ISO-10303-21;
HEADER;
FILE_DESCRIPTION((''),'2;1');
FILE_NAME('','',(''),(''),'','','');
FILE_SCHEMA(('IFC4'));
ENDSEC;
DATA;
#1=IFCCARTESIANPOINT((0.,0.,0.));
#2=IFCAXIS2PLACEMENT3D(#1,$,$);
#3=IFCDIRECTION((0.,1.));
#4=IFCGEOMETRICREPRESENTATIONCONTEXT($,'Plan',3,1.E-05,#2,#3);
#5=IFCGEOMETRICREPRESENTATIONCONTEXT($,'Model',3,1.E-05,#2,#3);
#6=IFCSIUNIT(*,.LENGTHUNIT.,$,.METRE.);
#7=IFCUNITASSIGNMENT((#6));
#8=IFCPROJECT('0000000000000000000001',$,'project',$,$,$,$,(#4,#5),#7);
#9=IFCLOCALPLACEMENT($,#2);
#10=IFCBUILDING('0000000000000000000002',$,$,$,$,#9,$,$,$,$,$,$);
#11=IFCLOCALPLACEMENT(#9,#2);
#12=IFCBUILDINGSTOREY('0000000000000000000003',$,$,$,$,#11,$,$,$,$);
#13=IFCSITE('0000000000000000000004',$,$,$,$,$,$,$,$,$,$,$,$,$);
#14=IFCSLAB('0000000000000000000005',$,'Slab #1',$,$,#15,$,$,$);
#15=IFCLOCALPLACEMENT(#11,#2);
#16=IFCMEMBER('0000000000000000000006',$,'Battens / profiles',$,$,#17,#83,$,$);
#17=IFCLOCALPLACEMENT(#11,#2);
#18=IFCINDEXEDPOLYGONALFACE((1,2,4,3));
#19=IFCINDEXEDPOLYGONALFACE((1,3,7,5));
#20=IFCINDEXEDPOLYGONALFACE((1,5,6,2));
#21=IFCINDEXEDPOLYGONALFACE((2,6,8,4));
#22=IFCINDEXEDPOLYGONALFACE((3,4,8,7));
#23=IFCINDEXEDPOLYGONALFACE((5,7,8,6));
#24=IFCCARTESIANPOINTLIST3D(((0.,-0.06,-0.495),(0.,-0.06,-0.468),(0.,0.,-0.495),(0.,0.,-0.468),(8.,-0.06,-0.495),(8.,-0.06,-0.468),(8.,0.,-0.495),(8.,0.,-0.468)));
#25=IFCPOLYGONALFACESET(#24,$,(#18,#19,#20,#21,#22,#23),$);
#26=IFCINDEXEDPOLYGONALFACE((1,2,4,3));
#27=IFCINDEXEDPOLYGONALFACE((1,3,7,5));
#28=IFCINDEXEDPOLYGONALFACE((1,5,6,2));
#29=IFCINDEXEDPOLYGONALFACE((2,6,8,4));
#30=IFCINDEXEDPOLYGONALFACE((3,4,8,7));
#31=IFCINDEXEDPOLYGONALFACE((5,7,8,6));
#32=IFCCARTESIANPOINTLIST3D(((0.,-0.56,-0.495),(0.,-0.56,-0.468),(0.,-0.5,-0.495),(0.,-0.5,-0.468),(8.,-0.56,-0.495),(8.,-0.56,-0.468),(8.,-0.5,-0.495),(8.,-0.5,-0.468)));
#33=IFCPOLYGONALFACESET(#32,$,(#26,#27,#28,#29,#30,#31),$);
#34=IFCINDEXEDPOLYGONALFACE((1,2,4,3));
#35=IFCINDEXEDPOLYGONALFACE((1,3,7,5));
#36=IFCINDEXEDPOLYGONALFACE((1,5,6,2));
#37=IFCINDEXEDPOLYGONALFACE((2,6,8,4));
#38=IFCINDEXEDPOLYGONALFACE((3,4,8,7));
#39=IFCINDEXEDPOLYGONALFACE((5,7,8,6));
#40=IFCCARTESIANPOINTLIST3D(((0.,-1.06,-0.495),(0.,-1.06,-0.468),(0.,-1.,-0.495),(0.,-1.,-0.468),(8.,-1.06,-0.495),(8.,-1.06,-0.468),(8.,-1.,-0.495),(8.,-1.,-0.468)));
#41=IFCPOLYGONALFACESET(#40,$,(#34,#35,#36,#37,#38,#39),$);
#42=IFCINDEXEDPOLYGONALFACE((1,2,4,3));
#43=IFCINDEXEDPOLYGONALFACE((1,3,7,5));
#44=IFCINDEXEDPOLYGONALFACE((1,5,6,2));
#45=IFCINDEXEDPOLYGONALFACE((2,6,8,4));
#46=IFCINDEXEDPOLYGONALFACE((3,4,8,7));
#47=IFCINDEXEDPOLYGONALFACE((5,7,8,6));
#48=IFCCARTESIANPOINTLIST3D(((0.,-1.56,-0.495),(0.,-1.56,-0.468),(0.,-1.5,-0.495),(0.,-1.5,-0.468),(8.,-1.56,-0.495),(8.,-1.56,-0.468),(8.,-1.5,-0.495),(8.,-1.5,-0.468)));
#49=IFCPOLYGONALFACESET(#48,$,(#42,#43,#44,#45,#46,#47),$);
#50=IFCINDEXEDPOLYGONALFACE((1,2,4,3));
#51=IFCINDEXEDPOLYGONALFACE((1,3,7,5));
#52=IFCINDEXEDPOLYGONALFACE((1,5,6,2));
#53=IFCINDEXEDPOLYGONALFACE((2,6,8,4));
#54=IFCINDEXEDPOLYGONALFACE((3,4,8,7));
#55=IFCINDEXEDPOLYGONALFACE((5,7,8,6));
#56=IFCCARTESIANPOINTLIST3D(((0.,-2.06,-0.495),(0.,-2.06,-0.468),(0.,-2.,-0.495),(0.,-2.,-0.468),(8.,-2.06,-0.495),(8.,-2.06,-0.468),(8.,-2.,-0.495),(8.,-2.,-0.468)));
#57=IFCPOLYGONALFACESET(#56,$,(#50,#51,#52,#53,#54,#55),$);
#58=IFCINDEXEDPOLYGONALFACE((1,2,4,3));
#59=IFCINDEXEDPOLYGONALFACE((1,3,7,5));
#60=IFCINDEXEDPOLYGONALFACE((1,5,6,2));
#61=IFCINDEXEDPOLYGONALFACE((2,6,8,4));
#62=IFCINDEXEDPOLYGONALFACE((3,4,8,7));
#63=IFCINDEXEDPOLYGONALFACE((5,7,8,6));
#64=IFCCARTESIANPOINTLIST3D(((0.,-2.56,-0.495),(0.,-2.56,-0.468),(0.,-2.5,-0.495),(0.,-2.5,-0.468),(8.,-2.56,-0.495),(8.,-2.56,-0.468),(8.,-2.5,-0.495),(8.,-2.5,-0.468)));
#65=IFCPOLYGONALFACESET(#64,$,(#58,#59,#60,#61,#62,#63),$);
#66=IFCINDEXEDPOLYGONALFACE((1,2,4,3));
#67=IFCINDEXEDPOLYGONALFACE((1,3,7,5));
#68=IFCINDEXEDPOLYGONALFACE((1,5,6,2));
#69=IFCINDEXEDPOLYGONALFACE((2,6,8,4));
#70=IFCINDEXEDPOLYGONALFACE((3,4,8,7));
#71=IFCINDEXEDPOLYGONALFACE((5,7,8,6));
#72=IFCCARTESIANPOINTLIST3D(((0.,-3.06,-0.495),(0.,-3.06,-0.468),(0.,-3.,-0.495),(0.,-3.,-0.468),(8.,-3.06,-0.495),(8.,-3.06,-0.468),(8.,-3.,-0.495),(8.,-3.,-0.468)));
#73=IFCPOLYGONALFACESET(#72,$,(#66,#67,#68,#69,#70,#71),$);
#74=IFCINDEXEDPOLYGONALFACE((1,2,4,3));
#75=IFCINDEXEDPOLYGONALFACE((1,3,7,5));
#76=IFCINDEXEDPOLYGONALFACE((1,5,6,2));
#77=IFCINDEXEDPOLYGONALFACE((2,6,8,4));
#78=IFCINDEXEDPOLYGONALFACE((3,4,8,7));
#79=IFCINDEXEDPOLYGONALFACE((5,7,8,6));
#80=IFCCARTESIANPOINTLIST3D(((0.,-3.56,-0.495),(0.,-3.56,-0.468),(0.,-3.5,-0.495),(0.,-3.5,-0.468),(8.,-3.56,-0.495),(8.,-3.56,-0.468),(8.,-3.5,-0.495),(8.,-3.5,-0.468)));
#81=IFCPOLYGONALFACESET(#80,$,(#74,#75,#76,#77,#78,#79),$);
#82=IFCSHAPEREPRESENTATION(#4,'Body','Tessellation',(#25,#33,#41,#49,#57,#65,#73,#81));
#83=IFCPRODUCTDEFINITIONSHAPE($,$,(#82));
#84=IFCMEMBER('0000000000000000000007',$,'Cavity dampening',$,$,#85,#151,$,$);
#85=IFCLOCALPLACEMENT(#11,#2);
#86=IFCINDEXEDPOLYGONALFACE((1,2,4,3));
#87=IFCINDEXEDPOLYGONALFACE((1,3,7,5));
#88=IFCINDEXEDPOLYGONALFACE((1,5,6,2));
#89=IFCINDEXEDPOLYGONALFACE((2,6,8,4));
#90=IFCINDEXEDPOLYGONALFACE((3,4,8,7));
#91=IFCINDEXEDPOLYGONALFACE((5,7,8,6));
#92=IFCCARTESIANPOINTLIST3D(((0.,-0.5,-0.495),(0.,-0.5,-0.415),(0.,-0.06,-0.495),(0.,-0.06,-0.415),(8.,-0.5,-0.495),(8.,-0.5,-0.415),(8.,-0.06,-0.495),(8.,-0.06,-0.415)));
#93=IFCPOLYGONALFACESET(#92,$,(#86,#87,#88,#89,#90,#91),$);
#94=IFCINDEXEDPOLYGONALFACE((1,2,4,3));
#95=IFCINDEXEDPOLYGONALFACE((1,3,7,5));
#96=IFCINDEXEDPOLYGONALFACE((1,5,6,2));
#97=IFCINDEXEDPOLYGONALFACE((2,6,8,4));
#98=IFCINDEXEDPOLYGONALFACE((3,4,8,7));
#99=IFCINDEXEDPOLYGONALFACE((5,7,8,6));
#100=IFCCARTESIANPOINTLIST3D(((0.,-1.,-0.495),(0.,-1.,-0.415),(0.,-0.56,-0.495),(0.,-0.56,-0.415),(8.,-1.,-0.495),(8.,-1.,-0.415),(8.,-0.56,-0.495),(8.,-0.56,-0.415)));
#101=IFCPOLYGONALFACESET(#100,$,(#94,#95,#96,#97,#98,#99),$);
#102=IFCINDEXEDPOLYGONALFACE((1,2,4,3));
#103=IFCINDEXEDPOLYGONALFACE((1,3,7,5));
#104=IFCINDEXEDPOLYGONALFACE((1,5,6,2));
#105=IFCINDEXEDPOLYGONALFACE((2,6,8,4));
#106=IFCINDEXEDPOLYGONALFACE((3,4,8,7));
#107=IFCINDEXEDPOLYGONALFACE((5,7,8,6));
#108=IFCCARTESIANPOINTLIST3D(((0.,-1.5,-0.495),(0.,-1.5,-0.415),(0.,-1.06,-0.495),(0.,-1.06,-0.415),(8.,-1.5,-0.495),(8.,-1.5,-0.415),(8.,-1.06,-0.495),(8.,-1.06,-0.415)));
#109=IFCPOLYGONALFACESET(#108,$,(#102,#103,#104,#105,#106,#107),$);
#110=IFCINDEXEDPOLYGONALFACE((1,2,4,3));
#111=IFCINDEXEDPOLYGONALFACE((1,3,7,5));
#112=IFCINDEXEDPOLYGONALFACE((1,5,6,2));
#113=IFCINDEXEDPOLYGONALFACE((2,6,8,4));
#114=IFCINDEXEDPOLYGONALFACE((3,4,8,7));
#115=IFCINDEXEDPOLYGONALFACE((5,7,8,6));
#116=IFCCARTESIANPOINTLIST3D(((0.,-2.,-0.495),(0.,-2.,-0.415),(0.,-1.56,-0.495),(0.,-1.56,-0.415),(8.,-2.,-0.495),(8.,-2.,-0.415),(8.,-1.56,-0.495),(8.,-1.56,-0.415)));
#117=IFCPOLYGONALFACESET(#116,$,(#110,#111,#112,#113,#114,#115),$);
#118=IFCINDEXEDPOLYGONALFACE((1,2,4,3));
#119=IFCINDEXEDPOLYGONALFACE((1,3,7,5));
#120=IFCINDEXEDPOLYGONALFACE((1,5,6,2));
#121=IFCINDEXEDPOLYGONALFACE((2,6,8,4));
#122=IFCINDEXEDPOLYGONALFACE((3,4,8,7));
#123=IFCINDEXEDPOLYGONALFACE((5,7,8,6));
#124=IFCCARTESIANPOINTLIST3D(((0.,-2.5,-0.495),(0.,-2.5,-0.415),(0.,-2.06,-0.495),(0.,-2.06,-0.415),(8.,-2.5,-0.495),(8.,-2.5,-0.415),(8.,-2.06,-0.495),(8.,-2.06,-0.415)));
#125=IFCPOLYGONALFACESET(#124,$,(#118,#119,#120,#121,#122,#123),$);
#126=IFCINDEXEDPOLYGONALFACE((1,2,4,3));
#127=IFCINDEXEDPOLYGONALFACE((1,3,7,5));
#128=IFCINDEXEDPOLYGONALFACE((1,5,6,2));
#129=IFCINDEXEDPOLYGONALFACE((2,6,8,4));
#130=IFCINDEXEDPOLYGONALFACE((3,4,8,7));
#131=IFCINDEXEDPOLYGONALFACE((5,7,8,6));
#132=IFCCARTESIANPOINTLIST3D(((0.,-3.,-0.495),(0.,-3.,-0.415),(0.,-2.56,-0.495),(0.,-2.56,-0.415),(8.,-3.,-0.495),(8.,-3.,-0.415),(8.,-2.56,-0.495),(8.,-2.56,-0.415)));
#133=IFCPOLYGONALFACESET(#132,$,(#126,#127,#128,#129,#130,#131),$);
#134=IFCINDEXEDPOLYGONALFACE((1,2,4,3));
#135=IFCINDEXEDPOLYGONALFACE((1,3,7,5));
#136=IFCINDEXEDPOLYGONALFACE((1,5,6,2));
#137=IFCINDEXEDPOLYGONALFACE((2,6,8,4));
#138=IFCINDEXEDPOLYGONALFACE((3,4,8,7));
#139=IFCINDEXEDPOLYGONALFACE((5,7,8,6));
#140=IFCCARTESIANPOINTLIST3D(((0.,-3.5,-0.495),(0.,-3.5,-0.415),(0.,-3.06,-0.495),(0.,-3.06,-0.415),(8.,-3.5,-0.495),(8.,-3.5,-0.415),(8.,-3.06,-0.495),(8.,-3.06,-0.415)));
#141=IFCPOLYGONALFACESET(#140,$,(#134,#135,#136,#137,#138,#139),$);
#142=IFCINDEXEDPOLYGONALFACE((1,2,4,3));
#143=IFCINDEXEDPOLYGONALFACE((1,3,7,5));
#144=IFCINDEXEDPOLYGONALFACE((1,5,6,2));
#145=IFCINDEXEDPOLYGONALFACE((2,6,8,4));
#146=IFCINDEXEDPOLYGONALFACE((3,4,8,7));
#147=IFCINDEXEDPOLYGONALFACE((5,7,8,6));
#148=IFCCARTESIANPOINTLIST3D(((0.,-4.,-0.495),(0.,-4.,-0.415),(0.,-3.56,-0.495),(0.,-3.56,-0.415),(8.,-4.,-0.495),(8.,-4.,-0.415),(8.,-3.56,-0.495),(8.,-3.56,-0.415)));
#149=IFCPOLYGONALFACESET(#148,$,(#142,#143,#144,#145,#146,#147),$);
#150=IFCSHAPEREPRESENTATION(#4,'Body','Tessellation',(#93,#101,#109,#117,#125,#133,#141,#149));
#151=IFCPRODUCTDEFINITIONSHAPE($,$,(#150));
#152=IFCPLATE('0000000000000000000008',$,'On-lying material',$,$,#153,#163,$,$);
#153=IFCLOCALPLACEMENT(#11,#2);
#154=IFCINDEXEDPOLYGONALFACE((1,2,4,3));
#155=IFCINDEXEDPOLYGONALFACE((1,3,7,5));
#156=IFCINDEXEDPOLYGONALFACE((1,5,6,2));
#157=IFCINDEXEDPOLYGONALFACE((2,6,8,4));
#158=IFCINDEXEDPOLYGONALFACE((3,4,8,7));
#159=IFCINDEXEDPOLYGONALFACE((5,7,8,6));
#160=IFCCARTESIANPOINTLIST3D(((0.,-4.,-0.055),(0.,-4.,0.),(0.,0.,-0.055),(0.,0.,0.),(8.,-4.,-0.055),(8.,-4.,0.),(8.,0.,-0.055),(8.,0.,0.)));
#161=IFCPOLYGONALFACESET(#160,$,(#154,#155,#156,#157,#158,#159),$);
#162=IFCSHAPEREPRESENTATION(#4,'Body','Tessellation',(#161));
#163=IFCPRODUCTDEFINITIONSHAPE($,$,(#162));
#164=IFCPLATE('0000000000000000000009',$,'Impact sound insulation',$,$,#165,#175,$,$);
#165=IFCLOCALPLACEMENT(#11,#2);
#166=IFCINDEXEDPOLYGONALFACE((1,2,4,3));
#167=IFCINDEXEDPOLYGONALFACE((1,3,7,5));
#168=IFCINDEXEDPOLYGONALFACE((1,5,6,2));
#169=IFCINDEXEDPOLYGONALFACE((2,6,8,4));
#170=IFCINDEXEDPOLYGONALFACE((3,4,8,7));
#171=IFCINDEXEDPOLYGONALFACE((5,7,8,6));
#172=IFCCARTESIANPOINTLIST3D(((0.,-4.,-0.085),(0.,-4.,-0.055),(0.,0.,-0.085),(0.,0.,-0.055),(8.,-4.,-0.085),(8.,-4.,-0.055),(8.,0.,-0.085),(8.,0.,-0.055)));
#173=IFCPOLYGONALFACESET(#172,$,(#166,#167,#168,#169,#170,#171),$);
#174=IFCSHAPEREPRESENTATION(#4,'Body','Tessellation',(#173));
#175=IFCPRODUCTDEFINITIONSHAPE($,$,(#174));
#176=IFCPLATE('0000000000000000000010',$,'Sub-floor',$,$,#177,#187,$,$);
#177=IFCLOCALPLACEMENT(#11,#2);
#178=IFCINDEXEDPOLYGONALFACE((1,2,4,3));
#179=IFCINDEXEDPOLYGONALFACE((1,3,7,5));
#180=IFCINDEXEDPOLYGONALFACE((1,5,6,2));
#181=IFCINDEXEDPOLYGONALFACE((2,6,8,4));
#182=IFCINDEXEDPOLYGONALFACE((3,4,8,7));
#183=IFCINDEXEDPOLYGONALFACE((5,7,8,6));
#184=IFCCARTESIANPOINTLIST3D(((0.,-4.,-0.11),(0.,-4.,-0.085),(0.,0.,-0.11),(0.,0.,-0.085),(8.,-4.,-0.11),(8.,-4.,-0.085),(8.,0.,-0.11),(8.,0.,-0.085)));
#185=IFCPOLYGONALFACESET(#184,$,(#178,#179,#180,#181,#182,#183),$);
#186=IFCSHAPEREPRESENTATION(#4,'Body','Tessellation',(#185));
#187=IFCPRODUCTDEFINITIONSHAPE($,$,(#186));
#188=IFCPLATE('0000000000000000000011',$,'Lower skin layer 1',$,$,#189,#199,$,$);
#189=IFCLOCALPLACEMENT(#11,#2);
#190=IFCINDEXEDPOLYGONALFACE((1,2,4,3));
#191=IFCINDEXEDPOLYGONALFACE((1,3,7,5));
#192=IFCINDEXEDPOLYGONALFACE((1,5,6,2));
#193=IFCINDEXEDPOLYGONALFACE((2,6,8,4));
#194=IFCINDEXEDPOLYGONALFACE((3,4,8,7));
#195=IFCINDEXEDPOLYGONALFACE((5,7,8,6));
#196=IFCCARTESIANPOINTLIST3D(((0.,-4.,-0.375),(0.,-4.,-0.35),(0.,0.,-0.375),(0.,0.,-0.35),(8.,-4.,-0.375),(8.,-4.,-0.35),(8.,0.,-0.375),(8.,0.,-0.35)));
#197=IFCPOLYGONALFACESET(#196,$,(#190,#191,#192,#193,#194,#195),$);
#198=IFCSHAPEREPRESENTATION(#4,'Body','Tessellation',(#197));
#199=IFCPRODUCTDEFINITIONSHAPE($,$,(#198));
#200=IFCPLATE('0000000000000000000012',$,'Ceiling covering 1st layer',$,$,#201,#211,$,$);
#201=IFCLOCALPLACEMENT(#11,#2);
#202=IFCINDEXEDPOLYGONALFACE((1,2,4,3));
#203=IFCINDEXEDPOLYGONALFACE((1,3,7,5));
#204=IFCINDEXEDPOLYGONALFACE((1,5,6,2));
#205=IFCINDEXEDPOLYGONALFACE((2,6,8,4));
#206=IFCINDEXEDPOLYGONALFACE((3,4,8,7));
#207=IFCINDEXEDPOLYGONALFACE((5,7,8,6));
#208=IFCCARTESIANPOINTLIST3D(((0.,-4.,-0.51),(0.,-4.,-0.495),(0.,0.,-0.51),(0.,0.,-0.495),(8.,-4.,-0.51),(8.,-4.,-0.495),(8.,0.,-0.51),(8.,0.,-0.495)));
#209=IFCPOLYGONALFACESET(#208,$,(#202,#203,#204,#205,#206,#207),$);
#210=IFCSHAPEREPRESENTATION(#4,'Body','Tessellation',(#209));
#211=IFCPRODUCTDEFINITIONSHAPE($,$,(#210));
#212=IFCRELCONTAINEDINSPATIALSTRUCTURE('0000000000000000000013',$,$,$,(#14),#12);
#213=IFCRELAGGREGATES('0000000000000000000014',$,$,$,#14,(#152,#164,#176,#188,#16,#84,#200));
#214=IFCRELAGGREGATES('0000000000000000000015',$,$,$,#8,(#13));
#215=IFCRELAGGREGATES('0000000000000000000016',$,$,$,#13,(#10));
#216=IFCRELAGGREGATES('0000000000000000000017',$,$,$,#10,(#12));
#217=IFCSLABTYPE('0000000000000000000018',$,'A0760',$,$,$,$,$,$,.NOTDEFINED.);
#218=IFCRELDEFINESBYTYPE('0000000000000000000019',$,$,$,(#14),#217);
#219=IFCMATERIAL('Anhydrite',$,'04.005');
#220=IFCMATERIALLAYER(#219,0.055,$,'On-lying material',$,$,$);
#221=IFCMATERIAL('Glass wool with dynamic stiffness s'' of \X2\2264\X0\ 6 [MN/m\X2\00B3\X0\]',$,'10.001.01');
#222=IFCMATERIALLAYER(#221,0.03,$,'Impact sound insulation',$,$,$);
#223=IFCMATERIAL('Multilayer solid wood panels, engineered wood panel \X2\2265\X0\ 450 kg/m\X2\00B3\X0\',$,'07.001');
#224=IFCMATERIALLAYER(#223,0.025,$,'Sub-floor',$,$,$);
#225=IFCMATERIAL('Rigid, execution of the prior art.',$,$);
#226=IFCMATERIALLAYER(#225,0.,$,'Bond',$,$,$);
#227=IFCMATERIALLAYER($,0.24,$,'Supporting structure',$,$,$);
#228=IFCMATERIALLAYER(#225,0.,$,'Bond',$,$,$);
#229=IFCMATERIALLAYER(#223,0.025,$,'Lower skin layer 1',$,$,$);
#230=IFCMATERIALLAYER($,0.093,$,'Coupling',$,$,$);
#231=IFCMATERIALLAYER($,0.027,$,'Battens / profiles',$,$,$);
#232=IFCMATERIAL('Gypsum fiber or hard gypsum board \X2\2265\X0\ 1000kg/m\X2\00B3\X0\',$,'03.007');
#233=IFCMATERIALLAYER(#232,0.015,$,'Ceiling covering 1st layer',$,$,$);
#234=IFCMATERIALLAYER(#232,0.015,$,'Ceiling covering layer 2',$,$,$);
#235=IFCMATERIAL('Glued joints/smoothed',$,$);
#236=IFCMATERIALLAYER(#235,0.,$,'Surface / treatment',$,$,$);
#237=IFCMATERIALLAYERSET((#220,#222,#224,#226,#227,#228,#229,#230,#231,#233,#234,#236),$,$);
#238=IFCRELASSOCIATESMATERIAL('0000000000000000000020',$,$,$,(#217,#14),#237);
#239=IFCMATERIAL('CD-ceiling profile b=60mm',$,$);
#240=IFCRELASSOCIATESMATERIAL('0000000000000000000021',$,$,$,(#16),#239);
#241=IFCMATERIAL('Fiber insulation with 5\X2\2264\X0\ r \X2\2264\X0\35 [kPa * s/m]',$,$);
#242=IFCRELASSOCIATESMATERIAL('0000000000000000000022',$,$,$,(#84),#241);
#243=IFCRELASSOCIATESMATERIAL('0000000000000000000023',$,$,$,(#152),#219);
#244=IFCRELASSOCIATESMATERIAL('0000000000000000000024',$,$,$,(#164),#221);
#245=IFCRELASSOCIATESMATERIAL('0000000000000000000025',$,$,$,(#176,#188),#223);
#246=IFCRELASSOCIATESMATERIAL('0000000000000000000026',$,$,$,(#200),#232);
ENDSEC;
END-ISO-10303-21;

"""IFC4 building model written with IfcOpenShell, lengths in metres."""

from ifc_helpers import new_model, si_unit, direction, frame, frame_2d, origin, origin_with_axes, place, context, project, spatial, rectangle, extrude, material, layer, layer_set, type_object, element, aggregate, save


model = new_model("IFC4")

# Units and contexts
plan_context = context("Plan", 3, precision=1e-05, world=origin(), true_north=direction((0.0, 1.0)))
model_context = context("Model", 3, precision=1e-05, world=origin(), true_north=direction((0.0, 1.0)))
ifc_project = project(units=[si_unit("LENGTHUNIT", "METRE")], contexts=[plan_context, model_context])

# Site, building, storey
site = spatial("IfcSite", under=ifc_project)
building_placement = place(None, origin())
building = spatial("IfcBuilding", under=site, at=building_placement)
storey_placement = place(building_placement, origin())
storey = spatial("IfcBuildingStorey", under=building, at=storey_placement)

# Slab, members, plates
ifc_material_1 = material(Name="Anhydrite", Category="04.005")
ifc_layer_1 = layer(ifc_material_1, 0.055, Name="On-lying material")
ifc_material_2 = material(Name="Glass wool with dynamic stiffness s' of ≤ 6 [MN/m³]", Category="10.001.01")
ifc_layer_2 = layer(ifc_material_2, 0.03, Name="Impact sound insulation")
ifc_material_3 = material(Name="Multilayer solid wood panels, engineered wood panel ≥ 450 kg/m³", Category="07.001")
ifc_layer_3 = layer(ifc_material_3, 0.025, Name="Sub-floor")
ifc_material_4 = material(Name="Rigid, execution of the prior art.")
ifc_layer_4 = layer(ifc_material_4, 0.0, Name="Bond")
ifc_layer_5 = layer(None, 0.24, Name="Supporting structure")
ifc_layer_6 = layer(ifc_material_4, 0.0, Name="Bond")
ifc_layer_7 = layer(ifc_material_3, 0.025, Name="Lower skin layer 1")
ifc_layer_8 = layer(None, 0.093, Name="Coupling")
ifc_layer_9 = layer(None, 0.027, Name="Battens / profiles")
ifc_material_5 = material(Name="Gypsum fiber or hard gypsum board ≥ 1000kg/m³", Category="03.007")
ifc_layer_10 = layer(ifc_material_5, 0.015, Name="Ceiling covering 1st layer")
ifc_layer_11 = layer(ifc_material_5, 0.015, Name="Ceiling covering layer 2")
ifc_material_6 = material(Name="Glued joints/smoothed")
ifc_layer_12 = layer(ifc_material_6, 0.0, Name="Surface / treatment")
ifc_layer_set = layer_set([ifc_layer_1, ifc_layer_2, ifc_layer_3, ifc_layer_4, ifc_layer_5, ifc_layer_6, ifc_layer_7, ifc_layer_8, ifc_layer_9, ifc_layer_10, ifc_layer_11, ifc_layer_12])
slab_type = type_object("IfcSlabType", Name="A0760", PredefinedType="NOTDEFINED", material=ifc_layer_set)
slab_placement = place(None, frame((0.0, 0.0, 0.0), z_axis=(0.0, 0.0, -1.0), x_axis=(1.0, 0.0, 0.0)))
slab = element("IfcSlab", 1, at=slab_placement, inside=storey, type_object=slab_type, material=ifc_layer_set, Name="Slab #1")
ifc_material_7 = material(Name="CD-ceiling profile b=60mm")
member_1_placement = place(slab_placement, origin())
member_1 = element("IfcMember", 2, at=member_1_placement, material=ifc_material_7, Name="Battens / profiles", context=plan_context, shape_type="SweptSolid", body=[
    extrude(rectangle(XDim=0.06, YDim=0.027, at=frame_2d((0.03, 0.0135), x_axis=(1.0, 0.0))), frame((0.0, 0.0, 0.468), z_axis=(1.0, 0.0, 0.0), x_axis=(0.0, 1.0, 0.0)), (0.0, 0.0, 1.0), 8.0),
    extrude(rectangle(XDim=0.06, YDim=0.027, at=frame_2d((0.03, 0.0135), x_axis=(1.0, 0.0))), frame((0.0, 0.5, 0.468), z_axis=(1.0, 0.0, 0.0), x_axis=(0.0, 1.0, 0.0)), (0.0, 0.0, 1.0), 8.0),
    extrude(rectangle(XDim=0.06, YDim=0.027, at=frame_2d((0.03, 0.0135), x_axis=(1.0, 0.0))), frame((0.0, 1.0, 0.468), z_axis=(1.0, 0.0, 0.0), x_axis=(0.0, 1.0, 0.0)), (0.0, 0.0, 1.0), 8.0),
    extrude(rectangle(XDim=0.06, YDim=0.027, at=frame_2d((0.03, 0.0135), x_axis=(1.0, 0.0))), frame((0.0, 1.5, 0.468), z_axis=(1.0, 0.0, 0.0), x_axis=(0.0, 1.0, 0.0)), (0.0, 0.0, 1.0), 8.0),
    extrude(rectangle(XDim=0.06, YDim=0.027, at=frame_2d((0.03, 0.0135), x_axis=(1.0, 0.0))), frame((0.0, 2.0, 0.468), z_axis=(1.0, 0.0, 0.0), x_axis=(0.0, 1.0, 0.0)), (0.0, 0.0, 1.0), 8.0),
    extrude(rectangle(XDim=0.06, YDim=0.027, at=frame_2d((0.03, 0.0135), x_axis=(1.0, 0.0))), frame((0.0, 2.5, 0.468), z_axis=(1.0, 0.0, 0.0), x_axis=(0.0, 1.0, 0.0)), (0.0, 0.0, 1.0), 8.0),
    extrude(rectangle(XDim=0.06, YDim=0.027, at=frame_2d((0.03, 0.0135), x_axis=(1.0, 0.0))), frame((0.0, 3.0, 0.468), z_axis=(1.0, 0.0, 0.0), x_axis=(0.0, 1.0, 0.0)), (0.0, 0.0, 1.0), 8.0),
    extrude(rectangle(XDim=0.06, YDim=0.027, at=frame_2d((0.03, 0.0135), x_axis=(1.0, 0.0))), frame((0.0, 3.5, 0.468), z_axis=(1.0, 0.0, 0.0), x_axis=(0.0, 1.0, 0.0)), (0.0, 0.0, 1.0), 8.0),
])
ifc_material_8 = material(Name="Fiber insulation with 5≤ r ≤35 [kPa * s/m]")
member_2_placement = place(slab_placement, origin())
member_2 = element("IfcMember", 3, at=member_2_placement, material=ifc_material_8, Name="Cavity dampening", context=plan_context, shape_type="SweptSolid", body=[
    extrude(rectangle(XDim=0.44, YDim=0.08, at=frame_2d((0.22, 0.04), x_axis=(1.0, 0.0))), frame((0.0, 0.06, 0.415), z_axis=(1.0, 0.0, 0.0), x_axis=(0.0, 1.0, 0.0)), (0.0, 0.0, 1.0), 8.0),
    extrude(rectangle(XDim=0.44, YDim=0.08, at=frame_2d((0.22, 0.04), x_axis=(1.0, 0.0))), frame((0.0, 0.56, 0.415), z_axis=(1.0, 0.0, 0.0), x_axis=(0.0, 1.0, 0.0)), (0.0, 0.0, 1.0), 8.0),
    extrude(rectangle(XDim=0.44, YDim=0.08, at=frame_2d((0.22, 0.04), x_axis=(1.0, 0.0))), frame((0.0, 1.06, 0.415), z_axis=(1.0, 0.0, 0.0), x_axis=(0.0, 1.0, 0.0)), (0.0, 0.0, 1.0), 8.0),
    extrude(rectangle(XDim=0.44, YDim=0.08, at=frame_2d((0.22, 0.04), x_axis=(1.0, 0.0))), frame((0.0, 1.56, 0.415), z_axis=(1.0, 0.0, 0.0), x_axis=(0.0, 1.0, 0.0)), (0.0, 0.0, 1.0), 8.0),
    extrude(rectangle(XDim=0.44, YDim=0.08, at=frame_2d((0.22, 0.04), x_axis=(1.0, 0.0))), frame((0.0, 2.06, 0.415), z_axis=(1.0, 0.0, 0.0), x_axis=(0.0, 1.0, 0.0)), (0.0, 0.0, 1.0), 8.0),
    extrude(rectangle(XDim=0.44, YDim=0.08, at=frame_2d((0.22, 0.04), x_axis=(1.0, 0.0))), frame((0.0, 2.56, 0.415), z_axis=(1.0, 0.0, 0.0), x_axis=(0.0, 1.0, 0.0)), (0.0, 0.0, 1.0), 8.0),
    extrude(rectangle(XDim=0.44, YDim=0.08, at=frame_2d((0.22, 0.04), x_axis=(1.0, 0.0))), frame((0.0, 3.06, 0.415), z_axis=(1.0, 0.0, 0.0), x_axis=(0.0, 1.0, 0.0)), (0.0, 0.0, 1.0), 8.0),
    extrude(rectangle(XDim=0.44, YDim=0.08, at=frame_2d((0.22, 0.04), x_axis=(1.0, 0.0))), frame((0.0, 3.56, 0.415), z_axis=(1.0, 0.0, 0.0), x_axis=(0.0, 1.0, 0.0)), (0.0, 0.0, 1.0), 8.0),
])
plate_1_placement = place(slab_placement, origin())
plate_1 = element("IfcPlate", 4, at=plate_1_placement, material=ifc_material_1, Name="On-lying material", context=plan_context, shape_type="SweptSolid", body=[
    extrude(rectangle(XDim=8.0, YDim=4.0, at=frame_2d((4.0, 2.0), x_axis=(1.0, 0.0))), origin_with_axes(), (0.0, 0.0, 1.0), 0.055),
])
plate_2_placement = place(slab_placement, origin())
plate_2 = element("IfcPlate", 5, at=plate_2_placement, material=ifc_material_2, Name="Impact sound insulation", context=plan_context, shape_type="SweptSolid", body=[
    extrude(rectangle(XDim=8.0, YDim=4.0, at=frame_2d((4.0, 2.0), x_axis=(1.0, 0.0))), frame((0.0, 0.0, 0.055), z_axis=(0.0, 0.0, 1.0), x_axis=(1.0, 0.0, 0.0)), (0.0, 0.0, 1.0), 0.03),
])
plate_3_placement = place(slab_placement, origin())
plate_3 = element("IfcPlate", 6, at=plate_3_placement, material=ifc_material_3, Name="Sub-floor", context=plan_context, shape_type="SweptSolid", body=[
    extrude(rectangle(XDim=8.0, YDim=4.0, at=frame_2d((4.0, 2.0), x_axis=(1.0, 0.0))), frame((0.0, 0.0, 0.085), z_axis=(0.0, 0.0, 1.0), x_axis=(1.0, 0.0, 0.0)), (0.0, 0.0, 1.0), 0.025),
])
plate_4_placement = place(slab_placement, origin())
plate_4 = element("IfcPlate", 7, at=plate_4_placement, material=ifc_material_3, Name="Lower skin layer 1", context=plan_context, shape_type="SweptSolid", body=[
    extrude(rectangle(XDim=8.0, YDim=4.0, at=frame_2d((4.0, 2.0), x_axis=(1.0, 0.0))), frame((0.0, 0.0, 0.35), z_axis=(0.0, 0.0, 1.0), x_axis=(1.0, 0.0, 0.0)), (0.0, 0.0, 1.0), 0.025),
])
plate_5_placement = place(slab_placement, origin())
plate_5 = element("IfcPlate", 8, at=plate_5_placement, material=ifc_material_5, Name="Ceiling covering 1st layer", context=plan_context, shape_type="SweptSolid", body=[
    extrude(rectangle(XDim=8.0, YDim=4.0, at=frame_2d((4.0, 2.0), x_axis=(1.0, 0.0))), frame((0.0, 0.0, 0.495), z_axis=(0.0, 0.0, 1.0), x_axis=(1.0, 0.0, 0.0)), (0.0, 0.0, 1.0), 0.015),
])
aggregate(slab, [plate_1, plate_2, plate_3, plate_4, member_1, member_2, plate_5])

save(model, "model.ifc")
